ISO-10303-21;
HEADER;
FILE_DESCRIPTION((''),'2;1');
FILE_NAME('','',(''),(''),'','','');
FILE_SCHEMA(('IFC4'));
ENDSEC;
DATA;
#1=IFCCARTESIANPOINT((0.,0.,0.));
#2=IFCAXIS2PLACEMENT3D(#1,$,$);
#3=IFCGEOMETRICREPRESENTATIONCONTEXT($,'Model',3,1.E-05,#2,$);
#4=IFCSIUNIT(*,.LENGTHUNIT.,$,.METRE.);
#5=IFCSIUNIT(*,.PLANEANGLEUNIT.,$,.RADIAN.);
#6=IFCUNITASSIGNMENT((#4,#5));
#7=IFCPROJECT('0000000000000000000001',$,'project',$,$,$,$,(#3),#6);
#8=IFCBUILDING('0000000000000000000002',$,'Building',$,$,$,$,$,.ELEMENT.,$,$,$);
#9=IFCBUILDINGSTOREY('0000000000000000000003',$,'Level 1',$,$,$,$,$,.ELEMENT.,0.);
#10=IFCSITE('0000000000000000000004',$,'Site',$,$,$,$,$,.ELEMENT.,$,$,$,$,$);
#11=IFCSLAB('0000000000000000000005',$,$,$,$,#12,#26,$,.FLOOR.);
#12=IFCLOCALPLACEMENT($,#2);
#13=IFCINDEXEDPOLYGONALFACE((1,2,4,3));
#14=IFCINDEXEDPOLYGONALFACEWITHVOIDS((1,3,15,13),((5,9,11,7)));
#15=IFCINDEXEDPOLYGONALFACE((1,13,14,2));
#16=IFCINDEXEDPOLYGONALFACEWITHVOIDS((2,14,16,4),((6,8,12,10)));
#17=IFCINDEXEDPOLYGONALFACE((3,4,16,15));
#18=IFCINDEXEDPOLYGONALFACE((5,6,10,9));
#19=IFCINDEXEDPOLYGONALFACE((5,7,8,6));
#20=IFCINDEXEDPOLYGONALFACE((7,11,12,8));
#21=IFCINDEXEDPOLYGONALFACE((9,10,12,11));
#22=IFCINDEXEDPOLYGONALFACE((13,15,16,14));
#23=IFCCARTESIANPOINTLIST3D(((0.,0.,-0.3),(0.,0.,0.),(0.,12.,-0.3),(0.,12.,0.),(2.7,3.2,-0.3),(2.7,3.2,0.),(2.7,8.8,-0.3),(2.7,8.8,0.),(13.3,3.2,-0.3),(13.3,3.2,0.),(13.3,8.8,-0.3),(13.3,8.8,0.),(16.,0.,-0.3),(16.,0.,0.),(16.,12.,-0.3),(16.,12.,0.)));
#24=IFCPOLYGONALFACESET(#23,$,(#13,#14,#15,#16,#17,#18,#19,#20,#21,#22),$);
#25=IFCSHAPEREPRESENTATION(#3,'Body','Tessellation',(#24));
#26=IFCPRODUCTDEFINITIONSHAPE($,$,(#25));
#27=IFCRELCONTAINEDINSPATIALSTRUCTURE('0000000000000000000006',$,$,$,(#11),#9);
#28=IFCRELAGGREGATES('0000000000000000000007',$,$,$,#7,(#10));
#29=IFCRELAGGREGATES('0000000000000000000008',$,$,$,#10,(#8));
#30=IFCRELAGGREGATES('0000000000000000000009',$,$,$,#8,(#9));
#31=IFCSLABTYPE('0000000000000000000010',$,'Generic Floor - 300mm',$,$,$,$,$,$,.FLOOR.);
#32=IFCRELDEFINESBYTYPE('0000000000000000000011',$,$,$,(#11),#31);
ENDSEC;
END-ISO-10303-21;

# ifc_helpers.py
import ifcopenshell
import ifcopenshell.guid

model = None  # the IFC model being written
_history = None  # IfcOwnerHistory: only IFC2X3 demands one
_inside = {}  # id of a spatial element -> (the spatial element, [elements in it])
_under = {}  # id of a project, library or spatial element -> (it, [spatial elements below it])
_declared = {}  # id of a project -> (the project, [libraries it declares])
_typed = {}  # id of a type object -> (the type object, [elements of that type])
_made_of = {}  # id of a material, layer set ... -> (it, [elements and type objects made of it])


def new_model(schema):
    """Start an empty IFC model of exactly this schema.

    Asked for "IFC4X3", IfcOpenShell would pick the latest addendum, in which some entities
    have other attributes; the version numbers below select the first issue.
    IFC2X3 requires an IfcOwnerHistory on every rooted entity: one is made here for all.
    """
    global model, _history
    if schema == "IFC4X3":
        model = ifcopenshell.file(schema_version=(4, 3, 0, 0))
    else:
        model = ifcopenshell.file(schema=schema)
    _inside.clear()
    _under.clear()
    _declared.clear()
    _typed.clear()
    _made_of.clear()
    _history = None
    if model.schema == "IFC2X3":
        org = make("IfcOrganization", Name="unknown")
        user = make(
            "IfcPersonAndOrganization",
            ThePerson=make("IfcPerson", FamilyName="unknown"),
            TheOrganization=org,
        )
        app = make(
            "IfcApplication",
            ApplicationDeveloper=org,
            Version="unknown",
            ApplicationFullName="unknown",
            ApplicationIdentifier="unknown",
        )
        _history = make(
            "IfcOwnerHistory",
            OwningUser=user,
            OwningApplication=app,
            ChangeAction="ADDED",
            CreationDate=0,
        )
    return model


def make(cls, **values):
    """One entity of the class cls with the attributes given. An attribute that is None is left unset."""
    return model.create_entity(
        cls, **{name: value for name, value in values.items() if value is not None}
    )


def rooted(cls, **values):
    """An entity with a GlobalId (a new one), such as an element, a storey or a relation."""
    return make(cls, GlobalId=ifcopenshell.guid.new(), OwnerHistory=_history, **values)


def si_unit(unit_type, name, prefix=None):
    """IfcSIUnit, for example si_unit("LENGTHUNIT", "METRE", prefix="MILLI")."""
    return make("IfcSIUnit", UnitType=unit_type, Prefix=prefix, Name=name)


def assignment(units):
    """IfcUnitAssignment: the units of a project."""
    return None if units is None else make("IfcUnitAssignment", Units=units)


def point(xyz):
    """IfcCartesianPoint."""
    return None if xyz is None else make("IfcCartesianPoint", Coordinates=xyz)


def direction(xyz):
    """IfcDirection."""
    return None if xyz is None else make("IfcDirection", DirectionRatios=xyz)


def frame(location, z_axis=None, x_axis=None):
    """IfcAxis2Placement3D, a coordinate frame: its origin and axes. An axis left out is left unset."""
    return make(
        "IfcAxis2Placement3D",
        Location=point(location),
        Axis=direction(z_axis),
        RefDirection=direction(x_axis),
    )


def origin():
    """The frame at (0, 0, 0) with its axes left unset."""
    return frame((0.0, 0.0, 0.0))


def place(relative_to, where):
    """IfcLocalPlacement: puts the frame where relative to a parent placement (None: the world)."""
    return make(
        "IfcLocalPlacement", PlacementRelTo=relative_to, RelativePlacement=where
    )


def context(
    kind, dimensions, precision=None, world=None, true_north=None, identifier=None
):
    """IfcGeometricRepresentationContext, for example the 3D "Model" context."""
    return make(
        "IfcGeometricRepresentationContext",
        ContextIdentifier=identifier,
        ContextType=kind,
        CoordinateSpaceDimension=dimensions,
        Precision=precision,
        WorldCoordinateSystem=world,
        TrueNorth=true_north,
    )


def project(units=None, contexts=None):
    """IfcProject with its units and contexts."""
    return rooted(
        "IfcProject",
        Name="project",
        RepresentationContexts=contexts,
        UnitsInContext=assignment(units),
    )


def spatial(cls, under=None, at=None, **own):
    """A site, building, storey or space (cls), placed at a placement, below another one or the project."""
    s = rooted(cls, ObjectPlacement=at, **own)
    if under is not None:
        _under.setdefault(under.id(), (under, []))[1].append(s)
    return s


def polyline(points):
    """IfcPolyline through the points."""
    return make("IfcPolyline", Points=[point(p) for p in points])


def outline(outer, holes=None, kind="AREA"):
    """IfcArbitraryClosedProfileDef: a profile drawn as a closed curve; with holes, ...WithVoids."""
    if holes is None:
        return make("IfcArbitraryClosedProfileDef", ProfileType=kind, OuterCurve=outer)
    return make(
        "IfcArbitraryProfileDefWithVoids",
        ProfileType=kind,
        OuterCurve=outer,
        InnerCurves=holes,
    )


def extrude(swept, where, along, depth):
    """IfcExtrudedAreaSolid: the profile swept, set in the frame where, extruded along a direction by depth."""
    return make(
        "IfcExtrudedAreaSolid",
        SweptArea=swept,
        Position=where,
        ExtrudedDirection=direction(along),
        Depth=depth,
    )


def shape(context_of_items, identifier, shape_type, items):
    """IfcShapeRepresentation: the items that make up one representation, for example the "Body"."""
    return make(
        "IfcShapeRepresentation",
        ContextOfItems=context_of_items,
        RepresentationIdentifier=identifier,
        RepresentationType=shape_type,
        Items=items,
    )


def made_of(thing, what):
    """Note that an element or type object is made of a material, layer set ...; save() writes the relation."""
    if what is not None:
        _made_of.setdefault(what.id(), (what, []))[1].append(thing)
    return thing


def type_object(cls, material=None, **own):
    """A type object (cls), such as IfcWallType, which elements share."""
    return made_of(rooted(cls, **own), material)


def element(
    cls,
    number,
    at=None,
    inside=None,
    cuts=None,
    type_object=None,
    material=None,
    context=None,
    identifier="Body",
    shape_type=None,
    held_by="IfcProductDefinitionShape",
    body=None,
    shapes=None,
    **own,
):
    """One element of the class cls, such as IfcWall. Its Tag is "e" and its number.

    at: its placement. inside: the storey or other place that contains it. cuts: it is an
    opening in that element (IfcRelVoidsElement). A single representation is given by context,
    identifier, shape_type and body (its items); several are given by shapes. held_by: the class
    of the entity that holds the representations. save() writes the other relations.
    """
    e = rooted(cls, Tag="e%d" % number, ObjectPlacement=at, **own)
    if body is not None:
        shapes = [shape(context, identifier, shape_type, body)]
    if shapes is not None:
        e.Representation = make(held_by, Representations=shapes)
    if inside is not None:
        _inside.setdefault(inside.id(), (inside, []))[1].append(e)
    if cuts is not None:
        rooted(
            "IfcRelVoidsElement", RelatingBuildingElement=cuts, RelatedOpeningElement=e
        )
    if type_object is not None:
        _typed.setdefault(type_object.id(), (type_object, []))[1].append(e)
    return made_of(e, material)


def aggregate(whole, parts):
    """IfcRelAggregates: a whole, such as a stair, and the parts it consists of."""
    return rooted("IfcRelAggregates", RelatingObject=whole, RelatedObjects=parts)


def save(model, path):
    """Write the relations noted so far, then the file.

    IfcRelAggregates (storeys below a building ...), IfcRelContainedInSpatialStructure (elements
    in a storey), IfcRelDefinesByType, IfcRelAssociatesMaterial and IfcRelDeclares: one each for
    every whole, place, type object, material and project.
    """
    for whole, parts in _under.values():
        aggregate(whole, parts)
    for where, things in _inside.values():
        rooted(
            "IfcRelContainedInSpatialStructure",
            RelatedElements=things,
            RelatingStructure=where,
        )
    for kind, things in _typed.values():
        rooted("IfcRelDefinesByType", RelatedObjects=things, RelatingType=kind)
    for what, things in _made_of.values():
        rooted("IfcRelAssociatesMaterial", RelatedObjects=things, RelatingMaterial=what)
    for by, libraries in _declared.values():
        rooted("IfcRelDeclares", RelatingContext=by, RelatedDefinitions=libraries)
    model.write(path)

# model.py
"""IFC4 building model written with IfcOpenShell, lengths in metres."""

from ifc_helpers import new_model, si_unit, frame, origin, place, context, project, spatial, polyline, outline, extrude, type_object, element, save


model = new_model("IFC4")

# Units and contexts
model_context = context("Model", 3, precision=1e-05, world=origin())
ifc_project = project(units=[si_unit("LENGTHUNIT", "METRE"), si_unit("PLANEANGLEUNIT", "RADIAN")], contexts=[model_context])

# Site, building, storey
site = spatial("IfcSite", under=ifc_project, Name="Site", CompositionType="ELEMENT")
building = spatial("IfcBuilding", under=site, Name="Building", CompositionType="ELEMENT")
storey = spatial("IfcBuildingStorey", under=building, Name="Level 1", CompositionType="ELEMENT", Elevation=0.0)

# Slab, opening
slab_type = type_object("IfcSlabType", Name="Generic Floor - 300mm", PredefinedType="FLOOR")
slab_placement = place(None, origin())
slab = element("IfcSlab", 1, at=slab_placement, inside=storey, type_object=slab_type, PredefinedType="FLOOR", context=model_context, shape_type="SweptSolid", body=[
    extrude(outline(polyline([(0.0, 0.0), (16.0, 0.0), (16.0, 12.0), (0.0, 12.0), (0.0, 0.0)])), origin(), (0.0, 0.0, -1.0), 0.3),
])
opening_placement = place(None, frame((0.0, 0.0, 0.001)))
element("IfcOpeningElement", 2, at=opening_placement, cuts=slab, PredefinedType="OPENING", context=model_context, shape_type="SweptSolid", body=[
    extrude(outline(polyline([(2.7, 8.8), (2.7, 3.2), (13.3, 3.2), (13.3, 8.8), (2.7, 8.8)])), origin(), (0.0, 0.0, -1.0), 0.302),
])

save(model, "model.ifc")
